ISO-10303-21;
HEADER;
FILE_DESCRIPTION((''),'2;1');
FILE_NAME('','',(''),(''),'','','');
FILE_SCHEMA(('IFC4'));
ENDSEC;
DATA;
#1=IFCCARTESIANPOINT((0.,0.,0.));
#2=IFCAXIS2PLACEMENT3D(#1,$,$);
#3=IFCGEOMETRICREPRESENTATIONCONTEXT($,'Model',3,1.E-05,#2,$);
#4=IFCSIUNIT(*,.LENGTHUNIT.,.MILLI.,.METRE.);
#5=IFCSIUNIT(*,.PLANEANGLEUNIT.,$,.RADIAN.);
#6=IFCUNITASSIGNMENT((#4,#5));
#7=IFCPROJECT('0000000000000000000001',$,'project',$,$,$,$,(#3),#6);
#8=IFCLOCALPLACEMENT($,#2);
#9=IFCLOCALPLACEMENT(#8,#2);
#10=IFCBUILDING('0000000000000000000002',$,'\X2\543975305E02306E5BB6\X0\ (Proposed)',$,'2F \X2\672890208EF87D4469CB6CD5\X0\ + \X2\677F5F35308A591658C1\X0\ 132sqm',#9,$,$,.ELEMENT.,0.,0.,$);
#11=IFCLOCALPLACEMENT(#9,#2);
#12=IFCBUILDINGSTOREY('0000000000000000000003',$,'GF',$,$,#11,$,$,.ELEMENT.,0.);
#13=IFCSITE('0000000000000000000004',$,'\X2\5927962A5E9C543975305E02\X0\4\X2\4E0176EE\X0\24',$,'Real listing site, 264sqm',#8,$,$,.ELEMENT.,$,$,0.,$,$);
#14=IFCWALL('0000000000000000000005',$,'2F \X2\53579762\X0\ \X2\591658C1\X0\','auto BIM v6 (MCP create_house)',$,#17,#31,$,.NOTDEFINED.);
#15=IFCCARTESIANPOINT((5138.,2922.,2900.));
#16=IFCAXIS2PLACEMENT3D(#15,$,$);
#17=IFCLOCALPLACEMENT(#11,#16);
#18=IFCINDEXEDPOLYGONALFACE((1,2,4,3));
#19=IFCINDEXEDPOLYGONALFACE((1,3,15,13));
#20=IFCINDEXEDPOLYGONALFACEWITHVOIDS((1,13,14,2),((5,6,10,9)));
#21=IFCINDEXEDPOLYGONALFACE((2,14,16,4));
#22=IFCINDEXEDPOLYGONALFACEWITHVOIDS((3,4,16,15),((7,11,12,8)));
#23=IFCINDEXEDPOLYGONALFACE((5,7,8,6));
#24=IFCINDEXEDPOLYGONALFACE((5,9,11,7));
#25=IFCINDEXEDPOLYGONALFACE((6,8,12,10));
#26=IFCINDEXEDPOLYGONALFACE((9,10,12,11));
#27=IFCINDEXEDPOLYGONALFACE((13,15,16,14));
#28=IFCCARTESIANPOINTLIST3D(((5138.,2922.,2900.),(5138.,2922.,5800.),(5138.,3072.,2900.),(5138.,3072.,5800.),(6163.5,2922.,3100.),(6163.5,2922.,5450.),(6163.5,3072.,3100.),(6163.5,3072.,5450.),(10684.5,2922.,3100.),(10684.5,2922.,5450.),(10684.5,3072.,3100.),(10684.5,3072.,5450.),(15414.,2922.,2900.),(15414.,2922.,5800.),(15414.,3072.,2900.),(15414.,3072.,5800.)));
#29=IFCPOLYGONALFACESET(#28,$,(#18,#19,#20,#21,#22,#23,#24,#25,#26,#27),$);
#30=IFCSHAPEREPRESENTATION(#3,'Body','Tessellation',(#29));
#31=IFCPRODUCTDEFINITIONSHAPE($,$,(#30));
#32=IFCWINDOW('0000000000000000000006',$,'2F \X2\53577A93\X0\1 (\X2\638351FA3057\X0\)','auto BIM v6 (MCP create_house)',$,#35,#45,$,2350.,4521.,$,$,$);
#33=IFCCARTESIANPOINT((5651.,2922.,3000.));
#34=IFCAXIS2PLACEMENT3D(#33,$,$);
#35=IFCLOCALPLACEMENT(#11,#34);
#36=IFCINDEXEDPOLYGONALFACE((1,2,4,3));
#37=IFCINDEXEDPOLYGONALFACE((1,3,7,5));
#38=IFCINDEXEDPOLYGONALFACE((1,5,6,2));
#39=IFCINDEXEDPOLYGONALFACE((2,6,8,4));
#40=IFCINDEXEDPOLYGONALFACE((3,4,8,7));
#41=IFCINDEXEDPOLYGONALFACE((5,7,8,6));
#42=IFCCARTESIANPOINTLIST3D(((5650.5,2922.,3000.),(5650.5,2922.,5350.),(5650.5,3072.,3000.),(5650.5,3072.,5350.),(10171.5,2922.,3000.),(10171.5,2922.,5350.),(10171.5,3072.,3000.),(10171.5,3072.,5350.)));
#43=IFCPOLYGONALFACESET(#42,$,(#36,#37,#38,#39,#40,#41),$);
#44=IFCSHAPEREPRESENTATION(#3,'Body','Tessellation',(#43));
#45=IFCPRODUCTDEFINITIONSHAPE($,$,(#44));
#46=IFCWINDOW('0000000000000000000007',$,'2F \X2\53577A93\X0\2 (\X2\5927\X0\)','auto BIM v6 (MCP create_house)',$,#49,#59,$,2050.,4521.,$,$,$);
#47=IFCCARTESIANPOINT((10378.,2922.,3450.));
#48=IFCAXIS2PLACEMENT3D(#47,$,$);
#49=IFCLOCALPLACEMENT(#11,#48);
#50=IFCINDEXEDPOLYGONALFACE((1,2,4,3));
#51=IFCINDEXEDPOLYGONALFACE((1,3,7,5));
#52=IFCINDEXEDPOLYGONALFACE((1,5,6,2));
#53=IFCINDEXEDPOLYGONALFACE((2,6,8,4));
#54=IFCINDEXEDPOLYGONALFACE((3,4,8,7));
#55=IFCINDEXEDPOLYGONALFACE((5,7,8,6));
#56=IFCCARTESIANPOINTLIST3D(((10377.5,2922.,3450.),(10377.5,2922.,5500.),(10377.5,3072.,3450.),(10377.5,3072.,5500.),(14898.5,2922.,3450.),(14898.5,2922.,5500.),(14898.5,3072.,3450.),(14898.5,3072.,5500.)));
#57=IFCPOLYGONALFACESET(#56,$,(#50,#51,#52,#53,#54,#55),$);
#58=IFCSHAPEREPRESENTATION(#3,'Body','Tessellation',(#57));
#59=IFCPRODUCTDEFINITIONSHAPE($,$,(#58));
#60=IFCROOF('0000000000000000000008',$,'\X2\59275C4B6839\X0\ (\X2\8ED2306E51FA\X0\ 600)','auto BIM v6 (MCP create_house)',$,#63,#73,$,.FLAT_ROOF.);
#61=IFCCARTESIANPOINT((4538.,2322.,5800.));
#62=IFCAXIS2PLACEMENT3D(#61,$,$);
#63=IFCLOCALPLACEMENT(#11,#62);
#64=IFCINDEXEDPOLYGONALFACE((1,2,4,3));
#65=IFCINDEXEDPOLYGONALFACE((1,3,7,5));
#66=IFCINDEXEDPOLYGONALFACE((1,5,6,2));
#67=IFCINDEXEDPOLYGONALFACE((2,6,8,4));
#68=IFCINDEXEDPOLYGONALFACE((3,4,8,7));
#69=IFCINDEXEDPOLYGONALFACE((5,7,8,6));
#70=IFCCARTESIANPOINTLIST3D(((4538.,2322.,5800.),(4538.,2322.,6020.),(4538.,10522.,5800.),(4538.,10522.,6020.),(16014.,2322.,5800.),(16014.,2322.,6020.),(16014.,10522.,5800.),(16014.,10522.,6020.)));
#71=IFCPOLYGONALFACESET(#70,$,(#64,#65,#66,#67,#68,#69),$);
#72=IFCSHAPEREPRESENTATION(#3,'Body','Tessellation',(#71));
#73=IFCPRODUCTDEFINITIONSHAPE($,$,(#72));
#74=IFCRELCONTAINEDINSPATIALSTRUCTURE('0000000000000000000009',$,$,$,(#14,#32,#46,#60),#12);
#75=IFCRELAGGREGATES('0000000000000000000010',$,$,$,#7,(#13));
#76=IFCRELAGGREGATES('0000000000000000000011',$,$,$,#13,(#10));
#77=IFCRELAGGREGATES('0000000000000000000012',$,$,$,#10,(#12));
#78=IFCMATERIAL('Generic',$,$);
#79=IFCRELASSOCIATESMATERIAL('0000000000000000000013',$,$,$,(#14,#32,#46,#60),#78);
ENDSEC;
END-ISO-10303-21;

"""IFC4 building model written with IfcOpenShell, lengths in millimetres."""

from ifc_helpers import new_model, si_unit, frame, frame_2d, origin, place, context, project, spatial, rectangle, extrude, material, element, fill, save


model = new_model("IFC4")

# Units and contexts
model_context = context("Model", 3, precision=1e-05, world=origin())
ifc_project = project(units=[si_unit("LENGTHUNIT", "METRE", prefix="MILLI"), si_unit("PLANEANGLEUNIT", "RADIAN")], contexts=[model_context])

# Site, building, storey
site_placement = place(None, origin())
site = spatial("IfcSite", under=ifc_project, at=site_placement, Name="大阪府吹田市4丁目24", ObjectType="Real listing site, 264sqm", CompositionType="ELEMENT", RefElevation=0.0)
building_placement = place(site_placement, origin())
building = spatial("IfcBuilding", under=site, at=building_placement, Name="吹田市の家 (Proposed)", ObjectType="2F 木造軸組構法 + 板張り外壁 132sqm", CompositionType="ELEMENT", ElevationOfRefHeight=0.0, ElevationOfTerrain=0.0)
storey_placement = place(building_placement, origin())
storey = spatial("IfcBuildingStorey", under=building, at=storey_placement, Name="GF", CompositionType="ELEMENT", Elevation=0.0)

# Shared definitions
ifc_material = material(Name="Generic")

# Wall, openings, windows
wall_1_placement = place(storey_placement, frame((5138.0, 2922.0, 2900.0)))
wall_1 = element("IfcWall", 1, at=wall_1_placement, inside=storey, material=ifc_material, Name="2F 南面 外壁", Description="auto BIM v6 (MCP create_house)", PredefinedType="NOTDEFINED", context=model_context, shape_type="SweptSolid", body=[
    extrude(rectangle(XDim=10276.0, YDim=150.0, at=frame_2d((5138.0, 75.0))), frame((5138.0, 2922.0, 2900.0)), (0.0, 0.0, 1.0), 2900.0),
])
opening_1_placement = place(storey_placement, frame((5651.0, 2922.0, 3000.0)))
opening_1 = element("IfcOpeningElement", 2, at=opening_1_placement, cuts=wall_1, PredefinedType="NOTDEFINED", context=model_context, shape_type="SweptSolid", body=[
    extrude(rectangle(XDim=4521.0, YDim=150.0, at=frame_2d((2260.0, 75.0))), frame((5651.0, 2922.0, 3000.0)), (0.0, 0.0, 1.0), 2350.0),
])
opening_2_placement = place(storey_placement, frame((10378.0, 2922.0, 3450.0)))
opening_2 = element("IfcOpeningElement", 3, at=opening_2_placement, cuts=wall_1, PredefinedType="NOTDEFINED", context=model_context, shape_type="SweptSolid", body=[
    extrude(rectangle(XDim=4521.0, YDim=150.0, at=frame_2d((2260.0, 75.0))), frame((10378.0, 2922.0, 3450.0)), (0.0, 0.0, 1.0), 2050.0),
])
window_1_placement = place(storey_placement, frame((5651.0, 2922.0, 3000.0)))
window_1 = element("IfcWindow", 4, at=window_1_placement, inside=storey, material=ifc_material, Name="2F 南窓1 (掃出し)", Description="auto BIM v6 (MCP create_house)", OverallHeight=2350.0, OverallWidth=4521.0, context=model_context, shape_type="SweptSolid", body=[
    extrude(rectangle(XDim=4521.0, YDim=150.0, at=frame_2d((2260.0, 75.0))), frame((5651.0, 2922.0, 3000.0)), (0.0, 0.0, 1.0), 2350.0),
])
fill(opening_1, window_1)
window_2_placement = place(storey_placement, frame((10378.0, 2922.0, 3450.0)))
window_2 = element("IfcWindow", 5, at=window_2_placement, inside=storey, material=ifc_material, Name="2F 南窓2 (大)", Description="auto BIM v6 (MCP create_house)", OverallHeight=2050.0, OverallWidth=4521.0, context=model_context, shape_type="SweptSolid", body=[
    extrude(rectangle(XDim=4521.0, YDim=150.0, at=frame_2d((2260.0, 75.0))), frame((10378.0, 2922.0, 3450.0)), (0.0, 0.0, 1.0), 2050.0),
])
fill(opening_2, window_2)

# Roof
roof_placement = place(storey_placement, frame((4538.0, 2322.0, 5800.0)))
element("IfcRoof", 6, at=roof_placement, inside=storey, material=ifc_material, Name="大屋根 (軒の出 600)", Description="auto BIM v6 (MCP create_house)", PredefinedType="FLAT_ROOF", context=model_context, shape_type="SweptSolid", body=[
    extrude(rectangle(XDim=11476.0, YDim=8200.0, at=frame_2d((5738.0, 4100.0))), frame((4538.0, 2322.0, 5800.0)), (0.0, 0.0, 1.0), 220.0),
])

save(model, "model.ifc")
